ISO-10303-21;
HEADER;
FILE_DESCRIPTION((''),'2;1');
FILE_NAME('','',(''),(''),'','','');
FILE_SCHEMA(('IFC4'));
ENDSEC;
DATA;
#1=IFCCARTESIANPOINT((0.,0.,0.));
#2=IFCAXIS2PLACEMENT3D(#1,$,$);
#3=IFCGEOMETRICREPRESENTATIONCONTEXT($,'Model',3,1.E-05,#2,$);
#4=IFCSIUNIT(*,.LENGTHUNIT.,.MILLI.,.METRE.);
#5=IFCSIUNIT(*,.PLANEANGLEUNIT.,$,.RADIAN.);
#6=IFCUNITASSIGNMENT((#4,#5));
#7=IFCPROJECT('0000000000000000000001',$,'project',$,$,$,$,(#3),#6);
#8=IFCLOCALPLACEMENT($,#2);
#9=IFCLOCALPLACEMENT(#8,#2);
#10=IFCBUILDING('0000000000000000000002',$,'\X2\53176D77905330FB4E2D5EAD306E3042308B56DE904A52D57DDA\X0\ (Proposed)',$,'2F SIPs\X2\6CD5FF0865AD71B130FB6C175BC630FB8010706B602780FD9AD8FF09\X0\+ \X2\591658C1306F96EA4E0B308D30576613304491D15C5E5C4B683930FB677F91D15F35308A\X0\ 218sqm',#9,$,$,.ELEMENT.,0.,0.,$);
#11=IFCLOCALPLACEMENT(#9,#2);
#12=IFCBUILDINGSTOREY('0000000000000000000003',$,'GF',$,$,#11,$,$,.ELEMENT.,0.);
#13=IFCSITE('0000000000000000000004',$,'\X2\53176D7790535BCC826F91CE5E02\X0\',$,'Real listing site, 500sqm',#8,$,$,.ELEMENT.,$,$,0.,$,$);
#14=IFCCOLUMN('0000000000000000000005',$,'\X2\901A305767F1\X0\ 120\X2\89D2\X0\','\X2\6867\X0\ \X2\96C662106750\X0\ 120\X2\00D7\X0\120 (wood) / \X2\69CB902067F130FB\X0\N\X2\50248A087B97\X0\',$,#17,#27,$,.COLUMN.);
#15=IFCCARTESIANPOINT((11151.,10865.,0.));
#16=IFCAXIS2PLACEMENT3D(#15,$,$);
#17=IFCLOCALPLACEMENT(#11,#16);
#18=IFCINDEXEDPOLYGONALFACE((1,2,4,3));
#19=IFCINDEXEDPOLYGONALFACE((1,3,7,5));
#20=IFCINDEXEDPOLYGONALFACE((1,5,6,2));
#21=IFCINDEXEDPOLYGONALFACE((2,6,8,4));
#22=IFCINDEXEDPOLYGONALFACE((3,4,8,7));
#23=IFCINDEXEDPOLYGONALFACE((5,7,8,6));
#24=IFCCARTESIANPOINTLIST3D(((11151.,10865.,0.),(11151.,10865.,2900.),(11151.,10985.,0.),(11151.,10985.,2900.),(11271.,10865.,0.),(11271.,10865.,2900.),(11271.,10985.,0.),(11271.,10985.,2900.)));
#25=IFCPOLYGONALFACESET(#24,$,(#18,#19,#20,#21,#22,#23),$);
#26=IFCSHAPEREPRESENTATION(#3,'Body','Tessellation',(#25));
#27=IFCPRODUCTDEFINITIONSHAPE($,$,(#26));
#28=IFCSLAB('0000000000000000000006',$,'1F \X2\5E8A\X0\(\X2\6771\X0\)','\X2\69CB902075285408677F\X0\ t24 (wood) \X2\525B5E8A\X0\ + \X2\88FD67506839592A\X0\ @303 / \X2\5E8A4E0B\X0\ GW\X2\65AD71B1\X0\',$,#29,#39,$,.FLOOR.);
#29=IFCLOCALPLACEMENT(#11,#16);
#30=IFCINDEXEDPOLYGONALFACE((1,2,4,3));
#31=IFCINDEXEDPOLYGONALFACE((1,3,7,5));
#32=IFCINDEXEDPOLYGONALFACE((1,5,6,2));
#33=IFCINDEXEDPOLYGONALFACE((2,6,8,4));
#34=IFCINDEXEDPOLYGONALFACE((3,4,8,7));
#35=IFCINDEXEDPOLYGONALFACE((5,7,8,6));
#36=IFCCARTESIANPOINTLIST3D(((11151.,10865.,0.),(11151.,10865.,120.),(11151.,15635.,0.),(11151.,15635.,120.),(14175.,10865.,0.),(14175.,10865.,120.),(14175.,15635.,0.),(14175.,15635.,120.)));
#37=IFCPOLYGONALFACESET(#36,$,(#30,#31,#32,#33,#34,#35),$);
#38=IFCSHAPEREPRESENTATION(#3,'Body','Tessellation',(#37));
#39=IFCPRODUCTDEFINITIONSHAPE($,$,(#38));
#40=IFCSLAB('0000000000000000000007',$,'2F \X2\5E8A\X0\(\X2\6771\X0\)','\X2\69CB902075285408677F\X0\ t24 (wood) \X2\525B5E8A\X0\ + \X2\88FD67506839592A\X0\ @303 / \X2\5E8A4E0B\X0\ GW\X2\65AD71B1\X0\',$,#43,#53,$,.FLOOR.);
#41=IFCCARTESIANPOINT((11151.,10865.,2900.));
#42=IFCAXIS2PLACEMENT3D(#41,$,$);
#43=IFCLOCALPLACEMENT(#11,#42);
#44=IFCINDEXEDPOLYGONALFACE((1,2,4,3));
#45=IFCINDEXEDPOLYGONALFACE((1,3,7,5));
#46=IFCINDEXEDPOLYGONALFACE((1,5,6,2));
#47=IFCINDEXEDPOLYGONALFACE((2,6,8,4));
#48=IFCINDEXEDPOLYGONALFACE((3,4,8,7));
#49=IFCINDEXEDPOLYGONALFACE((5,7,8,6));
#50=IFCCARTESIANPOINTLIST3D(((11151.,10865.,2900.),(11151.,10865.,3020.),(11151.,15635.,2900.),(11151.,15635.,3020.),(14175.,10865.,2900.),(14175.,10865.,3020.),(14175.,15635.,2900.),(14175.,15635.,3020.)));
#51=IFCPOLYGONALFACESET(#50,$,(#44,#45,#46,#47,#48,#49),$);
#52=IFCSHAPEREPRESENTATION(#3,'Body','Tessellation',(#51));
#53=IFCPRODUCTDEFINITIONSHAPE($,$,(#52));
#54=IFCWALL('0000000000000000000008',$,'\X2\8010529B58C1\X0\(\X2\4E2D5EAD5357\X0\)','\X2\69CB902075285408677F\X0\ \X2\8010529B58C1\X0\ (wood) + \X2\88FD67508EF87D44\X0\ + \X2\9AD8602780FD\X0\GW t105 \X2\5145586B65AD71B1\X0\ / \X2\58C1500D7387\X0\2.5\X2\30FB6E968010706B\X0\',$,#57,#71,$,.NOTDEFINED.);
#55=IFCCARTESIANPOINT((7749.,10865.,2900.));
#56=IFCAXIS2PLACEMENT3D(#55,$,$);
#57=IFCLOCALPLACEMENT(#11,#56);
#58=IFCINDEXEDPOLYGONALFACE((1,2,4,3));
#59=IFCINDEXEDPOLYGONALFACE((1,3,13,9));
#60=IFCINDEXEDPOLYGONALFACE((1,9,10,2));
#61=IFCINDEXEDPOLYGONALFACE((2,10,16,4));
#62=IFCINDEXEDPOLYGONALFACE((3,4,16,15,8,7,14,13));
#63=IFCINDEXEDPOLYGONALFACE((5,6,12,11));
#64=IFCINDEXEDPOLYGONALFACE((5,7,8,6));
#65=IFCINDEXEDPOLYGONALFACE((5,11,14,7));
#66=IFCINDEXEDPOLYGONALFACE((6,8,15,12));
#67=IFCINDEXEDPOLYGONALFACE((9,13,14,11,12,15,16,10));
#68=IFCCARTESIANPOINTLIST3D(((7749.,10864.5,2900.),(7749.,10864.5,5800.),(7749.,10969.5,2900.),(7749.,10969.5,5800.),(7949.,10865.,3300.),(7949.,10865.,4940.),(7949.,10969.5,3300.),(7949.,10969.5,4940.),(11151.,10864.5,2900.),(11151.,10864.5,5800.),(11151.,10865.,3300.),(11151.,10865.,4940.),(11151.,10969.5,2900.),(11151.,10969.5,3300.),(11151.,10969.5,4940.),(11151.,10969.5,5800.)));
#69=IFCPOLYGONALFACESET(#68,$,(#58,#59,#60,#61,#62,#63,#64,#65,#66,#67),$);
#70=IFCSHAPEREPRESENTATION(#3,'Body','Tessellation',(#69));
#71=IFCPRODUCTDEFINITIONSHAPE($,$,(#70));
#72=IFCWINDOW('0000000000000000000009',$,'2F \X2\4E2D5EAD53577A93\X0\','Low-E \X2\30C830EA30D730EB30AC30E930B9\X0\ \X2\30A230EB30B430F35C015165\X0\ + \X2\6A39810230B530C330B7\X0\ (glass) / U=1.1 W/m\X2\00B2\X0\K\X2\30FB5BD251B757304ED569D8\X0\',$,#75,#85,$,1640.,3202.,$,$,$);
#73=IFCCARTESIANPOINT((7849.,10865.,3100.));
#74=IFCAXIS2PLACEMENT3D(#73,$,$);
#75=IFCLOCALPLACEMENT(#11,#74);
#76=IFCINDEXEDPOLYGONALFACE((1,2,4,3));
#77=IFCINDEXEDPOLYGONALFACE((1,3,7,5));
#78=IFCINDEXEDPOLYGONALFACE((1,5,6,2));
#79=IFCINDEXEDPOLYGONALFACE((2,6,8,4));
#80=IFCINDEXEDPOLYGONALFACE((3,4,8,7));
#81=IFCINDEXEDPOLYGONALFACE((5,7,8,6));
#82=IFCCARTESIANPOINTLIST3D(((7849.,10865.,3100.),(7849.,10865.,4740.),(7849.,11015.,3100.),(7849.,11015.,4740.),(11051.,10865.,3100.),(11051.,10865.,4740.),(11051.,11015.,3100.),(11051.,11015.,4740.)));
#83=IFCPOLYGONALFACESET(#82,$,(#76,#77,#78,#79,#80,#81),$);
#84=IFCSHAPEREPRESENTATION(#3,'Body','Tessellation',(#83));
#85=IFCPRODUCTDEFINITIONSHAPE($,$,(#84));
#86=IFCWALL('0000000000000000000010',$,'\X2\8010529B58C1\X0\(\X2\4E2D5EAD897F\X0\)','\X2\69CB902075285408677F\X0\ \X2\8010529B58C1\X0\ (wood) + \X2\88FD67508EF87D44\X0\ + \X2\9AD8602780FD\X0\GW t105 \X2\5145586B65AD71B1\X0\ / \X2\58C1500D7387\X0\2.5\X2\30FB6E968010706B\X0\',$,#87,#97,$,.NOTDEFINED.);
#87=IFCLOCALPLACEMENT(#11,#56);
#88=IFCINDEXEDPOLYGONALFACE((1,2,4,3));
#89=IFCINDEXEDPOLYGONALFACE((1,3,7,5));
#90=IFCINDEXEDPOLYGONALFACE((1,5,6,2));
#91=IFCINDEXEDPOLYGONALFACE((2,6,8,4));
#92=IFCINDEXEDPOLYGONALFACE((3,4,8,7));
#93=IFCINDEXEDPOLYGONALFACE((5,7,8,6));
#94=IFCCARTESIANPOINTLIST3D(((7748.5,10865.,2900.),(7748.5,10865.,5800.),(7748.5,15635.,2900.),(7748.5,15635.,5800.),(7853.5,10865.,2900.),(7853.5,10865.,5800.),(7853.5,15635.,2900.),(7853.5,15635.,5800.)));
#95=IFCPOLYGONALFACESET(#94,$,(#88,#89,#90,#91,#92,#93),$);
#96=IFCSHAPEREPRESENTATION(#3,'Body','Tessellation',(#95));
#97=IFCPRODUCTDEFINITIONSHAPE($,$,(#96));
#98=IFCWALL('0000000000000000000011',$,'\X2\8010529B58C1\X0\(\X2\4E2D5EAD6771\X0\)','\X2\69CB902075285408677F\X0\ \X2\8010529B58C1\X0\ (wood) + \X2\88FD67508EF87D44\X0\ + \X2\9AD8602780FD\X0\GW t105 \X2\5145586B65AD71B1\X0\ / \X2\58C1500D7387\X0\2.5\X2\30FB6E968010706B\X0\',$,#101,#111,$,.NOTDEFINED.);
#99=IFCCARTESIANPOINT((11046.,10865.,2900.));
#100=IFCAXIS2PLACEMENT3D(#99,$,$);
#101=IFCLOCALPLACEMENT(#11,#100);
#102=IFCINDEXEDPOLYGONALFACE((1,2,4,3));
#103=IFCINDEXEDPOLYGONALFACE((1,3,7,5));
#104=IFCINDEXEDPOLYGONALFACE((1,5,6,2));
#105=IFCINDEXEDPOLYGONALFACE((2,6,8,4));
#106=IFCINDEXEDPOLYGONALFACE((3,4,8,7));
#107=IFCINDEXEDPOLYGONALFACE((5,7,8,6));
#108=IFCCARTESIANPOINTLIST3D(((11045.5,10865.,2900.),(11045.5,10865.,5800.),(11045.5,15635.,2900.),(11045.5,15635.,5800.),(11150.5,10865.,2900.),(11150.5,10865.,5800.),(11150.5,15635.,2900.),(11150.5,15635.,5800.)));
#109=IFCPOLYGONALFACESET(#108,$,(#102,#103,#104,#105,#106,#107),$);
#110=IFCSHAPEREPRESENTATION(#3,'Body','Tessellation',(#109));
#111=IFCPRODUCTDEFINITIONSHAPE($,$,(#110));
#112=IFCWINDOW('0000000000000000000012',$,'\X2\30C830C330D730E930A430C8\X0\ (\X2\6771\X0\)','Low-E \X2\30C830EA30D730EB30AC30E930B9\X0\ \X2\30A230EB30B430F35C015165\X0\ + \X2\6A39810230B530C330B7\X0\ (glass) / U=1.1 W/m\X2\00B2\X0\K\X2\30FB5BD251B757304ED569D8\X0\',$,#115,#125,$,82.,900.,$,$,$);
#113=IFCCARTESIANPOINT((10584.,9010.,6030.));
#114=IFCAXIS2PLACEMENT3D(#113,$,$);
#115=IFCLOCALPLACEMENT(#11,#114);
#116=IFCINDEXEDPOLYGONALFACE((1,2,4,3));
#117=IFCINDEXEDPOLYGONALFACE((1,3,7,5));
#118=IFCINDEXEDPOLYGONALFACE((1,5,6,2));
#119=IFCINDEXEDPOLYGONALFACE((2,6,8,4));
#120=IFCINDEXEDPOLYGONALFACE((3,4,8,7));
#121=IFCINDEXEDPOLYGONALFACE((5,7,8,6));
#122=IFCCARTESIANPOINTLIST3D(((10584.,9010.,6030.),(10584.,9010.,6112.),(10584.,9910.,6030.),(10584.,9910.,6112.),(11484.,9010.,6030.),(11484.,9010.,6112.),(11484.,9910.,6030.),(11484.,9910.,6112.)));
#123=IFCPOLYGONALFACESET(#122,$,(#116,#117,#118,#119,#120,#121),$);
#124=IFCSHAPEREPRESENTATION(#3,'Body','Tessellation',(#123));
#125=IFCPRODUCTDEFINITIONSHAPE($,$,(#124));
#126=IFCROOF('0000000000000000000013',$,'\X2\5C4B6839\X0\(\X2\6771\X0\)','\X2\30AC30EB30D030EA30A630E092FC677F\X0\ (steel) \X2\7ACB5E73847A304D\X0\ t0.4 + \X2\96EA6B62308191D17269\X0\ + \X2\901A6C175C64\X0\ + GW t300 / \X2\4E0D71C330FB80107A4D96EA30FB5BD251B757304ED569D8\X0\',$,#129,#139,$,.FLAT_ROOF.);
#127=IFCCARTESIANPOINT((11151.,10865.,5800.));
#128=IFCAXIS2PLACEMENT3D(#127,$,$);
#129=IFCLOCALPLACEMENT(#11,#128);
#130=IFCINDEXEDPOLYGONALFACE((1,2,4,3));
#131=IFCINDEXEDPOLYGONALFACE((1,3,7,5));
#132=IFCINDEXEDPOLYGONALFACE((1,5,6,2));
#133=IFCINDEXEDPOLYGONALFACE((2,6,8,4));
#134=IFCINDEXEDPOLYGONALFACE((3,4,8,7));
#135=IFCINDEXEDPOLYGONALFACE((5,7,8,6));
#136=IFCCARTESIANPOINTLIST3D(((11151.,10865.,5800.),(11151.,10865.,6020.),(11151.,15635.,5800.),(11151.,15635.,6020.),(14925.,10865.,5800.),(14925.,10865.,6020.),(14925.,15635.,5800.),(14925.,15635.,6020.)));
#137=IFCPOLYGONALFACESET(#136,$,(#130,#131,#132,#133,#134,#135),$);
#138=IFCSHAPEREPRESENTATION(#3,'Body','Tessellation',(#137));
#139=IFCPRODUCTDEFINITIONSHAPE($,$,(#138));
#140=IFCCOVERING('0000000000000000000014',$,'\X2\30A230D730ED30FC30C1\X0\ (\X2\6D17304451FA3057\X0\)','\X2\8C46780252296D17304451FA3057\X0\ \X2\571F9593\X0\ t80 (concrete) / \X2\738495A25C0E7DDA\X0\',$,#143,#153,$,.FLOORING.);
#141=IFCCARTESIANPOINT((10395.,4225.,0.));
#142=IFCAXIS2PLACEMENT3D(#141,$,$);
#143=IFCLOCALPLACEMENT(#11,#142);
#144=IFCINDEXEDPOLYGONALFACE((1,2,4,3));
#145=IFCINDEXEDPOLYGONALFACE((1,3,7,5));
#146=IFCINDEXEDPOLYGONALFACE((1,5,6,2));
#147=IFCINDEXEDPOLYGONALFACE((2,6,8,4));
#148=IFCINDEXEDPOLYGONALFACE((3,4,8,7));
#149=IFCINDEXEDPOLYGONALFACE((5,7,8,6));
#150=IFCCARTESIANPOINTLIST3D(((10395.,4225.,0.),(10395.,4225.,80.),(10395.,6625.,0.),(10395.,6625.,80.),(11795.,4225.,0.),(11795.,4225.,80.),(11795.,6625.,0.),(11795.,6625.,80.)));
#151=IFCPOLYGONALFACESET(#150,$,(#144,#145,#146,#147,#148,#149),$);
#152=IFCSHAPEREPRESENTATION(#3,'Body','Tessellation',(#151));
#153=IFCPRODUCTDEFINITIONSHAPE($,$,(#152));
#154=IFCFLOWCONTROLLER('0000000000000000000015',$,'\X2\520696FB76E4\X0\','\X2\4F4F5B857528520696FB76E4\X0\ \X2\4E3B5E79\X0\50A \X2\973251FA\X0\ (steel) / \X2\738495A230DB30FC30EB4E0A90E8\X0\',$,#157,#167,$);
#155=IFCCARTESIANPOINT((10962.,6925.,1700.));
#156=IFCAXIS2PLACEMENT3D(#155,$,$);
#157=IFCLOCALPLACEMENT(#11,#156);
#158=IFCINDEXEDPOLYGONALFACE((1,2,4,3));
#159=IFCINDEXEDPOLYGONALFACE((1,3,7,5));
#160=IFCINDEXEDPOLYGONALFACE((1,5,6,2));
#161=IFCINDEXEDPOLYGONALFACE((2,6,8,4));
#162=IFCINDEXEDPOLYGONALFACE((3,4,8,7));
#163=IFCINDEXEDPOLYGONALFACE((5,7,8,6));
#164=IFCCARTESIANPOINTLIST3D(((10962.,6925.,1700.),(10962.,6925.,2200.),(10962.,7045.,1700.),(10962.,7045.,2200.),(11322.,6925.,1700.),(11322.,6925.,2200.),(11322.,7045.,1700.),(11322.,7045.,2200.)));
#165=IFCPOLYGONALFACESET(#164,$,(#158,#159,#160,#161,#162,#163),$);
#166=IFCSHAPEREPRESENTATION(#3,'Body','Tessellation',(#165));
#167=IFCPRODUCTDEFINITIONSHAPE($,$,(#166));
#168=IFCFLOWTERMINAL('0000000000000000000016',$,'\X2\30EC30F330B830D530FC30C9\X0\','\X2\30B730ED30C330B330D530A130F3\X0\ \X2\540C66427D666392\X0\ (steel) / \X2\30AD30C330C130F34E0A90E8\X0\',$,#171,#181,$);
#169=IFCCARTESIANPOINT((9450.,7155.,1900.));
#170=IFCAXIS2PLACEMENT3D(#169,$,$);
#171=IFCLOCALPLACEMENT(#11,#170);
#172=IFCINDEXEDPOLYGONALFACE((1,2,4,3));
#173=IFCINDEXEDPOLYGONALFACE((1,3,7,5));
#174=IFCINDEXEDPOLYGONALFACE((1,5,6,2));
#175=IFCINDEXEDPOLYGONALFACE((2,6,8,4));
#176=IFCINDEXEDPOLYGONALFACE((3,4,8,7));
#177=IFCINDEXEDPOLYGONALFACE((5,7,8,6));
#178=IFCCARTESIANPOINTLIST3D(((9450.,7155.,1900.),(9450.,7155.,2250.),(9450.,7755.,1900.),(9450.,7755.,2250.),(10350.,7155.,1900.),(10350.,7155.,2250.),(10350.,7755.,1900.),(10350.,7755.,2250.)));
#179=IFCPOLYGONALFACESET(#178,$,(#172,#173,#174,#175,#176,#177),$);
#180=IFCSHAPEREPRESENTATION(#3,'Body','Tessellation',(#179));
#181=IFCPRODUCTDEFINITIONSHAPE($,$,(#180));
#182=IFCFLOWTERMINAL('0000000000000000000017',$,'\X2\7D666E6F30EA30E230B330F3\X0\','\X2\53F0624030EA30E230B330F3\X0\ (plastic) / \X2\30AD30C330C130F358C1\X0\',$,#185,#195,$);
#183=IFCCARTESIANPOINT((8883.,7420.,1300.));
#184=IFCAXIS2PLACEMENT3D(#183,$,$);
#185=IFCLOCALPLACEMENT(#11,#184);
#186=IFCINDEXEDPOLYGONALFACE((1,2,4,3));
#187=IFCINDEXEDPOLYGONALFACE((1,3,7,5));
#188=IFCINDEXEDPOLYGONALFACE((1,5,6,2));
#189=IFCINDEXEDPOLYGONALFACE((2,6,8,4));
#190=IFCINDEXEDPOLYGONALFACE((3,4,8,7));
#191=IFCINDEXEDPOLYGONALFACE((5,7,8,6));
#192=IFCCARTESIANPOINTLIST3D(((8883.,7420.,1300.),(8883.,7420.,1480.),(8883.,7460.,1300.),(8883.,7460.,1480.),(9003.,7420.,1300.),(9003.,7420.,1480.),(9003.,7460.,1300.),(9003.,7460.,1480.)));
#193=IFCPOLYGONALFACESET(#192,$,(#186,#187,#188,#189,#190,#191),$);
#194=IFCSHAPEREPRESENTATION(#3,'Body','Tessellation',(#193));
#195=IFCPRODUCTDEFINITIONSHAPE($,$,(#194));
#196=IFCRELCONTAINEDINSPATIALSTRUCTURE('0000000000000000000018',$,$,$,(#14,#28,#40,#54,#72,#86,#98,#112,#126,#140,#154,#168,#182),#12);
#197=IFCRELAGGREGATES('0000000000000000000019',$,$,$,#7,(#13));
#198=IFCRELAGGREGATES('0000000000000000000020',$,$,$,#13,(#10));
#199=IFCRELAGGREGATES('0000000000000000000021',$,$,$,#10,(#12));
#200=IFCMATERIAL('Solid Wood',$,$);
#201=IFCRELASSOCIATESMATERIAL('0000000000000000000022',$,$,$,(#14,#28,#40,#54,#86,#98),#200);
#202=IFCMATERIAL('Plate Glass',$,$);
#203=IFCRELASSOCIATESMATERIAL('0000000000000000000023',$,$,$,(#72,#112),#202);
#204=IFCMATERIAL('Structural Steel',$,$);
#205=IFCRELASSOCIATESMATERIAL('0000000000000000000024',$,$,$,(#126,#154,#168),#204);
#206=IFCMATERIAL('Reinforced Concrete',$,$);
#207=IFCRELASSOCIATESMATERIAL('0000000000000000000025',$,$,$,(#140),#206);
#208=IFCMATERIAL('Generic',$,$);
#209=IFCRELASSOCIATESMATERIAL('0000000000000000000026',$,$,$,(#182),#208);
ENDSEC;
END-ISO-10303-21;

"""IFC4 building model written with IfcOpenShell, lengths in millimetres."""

from ifc_helpers import new_model, si_unit, frame, frame_2d, origin, place, context, project, spatial, rectangle, extrude, material, element, fill, save


model = new_model("IFC4")

# Units and contexts
model_context = context("Model", 3, precision=1e-05, world=origin())
ifc_project = project(units=[si_unit("LENGTHUNIT", "METRE", prefix="MILLI"), si_unit("PLANEANGLEUNIT", "RADIAN")], contexts=[model_context])

# Site, building, storey
site_placement = place(None, origin())
site = spatial("IfcSite", under=ifc_project, at=site_placement, Name="北海道富良野市", ObjectType="Real listing site, 500sqm", CompositionType="ELEMENT", RefElevation=0.0)
building_placement = place(site_placement, origin())
building = spatial("IfcBuilding", under=site, at=building_placement, Name="北海道・中庭のある回遊動線 (Proposed)", ObjectType="2F SIPs法（断熱・気密・耐火性能高）+ 外壁は雪下ろし易い金属屋根・板金張り 218sqm", CompositionType="ELEMENT", ElevationOfRefHeight=0.0, ElevationOfTerrain=0.0)
storey_placement = place(building_placement, origin())
storey = spatial("IfcBuildingStorey", under=building, at=storey_placement, Name="GF", CompositionType="ELEMENT", Elevation=0.0)

# Column
ifc_material_1 = material(Name="Solid Wood")
column_1_placement = place(storey_placement, frame((11151.0, 10865.0, 0.0)))
element("IfcColumn", 1, at=column_1_placement, inside=storey, material=ifc_material_1, Name="通し柱 120角", Description="桧 集成材 120×120 (wood) / 構造柱・N値計算", PredefinedType="COLUMN", context=model_context, shape_type="SweptSolid", body=[
    extrude(rectangle(XDim=120.0, YDim=120.0, at=frame_2d((60.0, 60.0))), frame((11151.0, 10865.0, 0.0)), (0.0, 0.0, 1.0), 2900.0),
])

# Slabs
slab_1_placement = place(storey_placement, frame((11151.0, 10865.0, 0.0)))
element("IfcSlab", 2, at=slab_1_placement, inside=storey, material=ifc_material_1, Name="1F 床(東)", Description="構造用合板 t24 (wood) 剛床 + 製材根太 @303 / 床下 GW断熱", PredefinedType="FLOOR", context=model_context, shape_type="SweptSolid", body=[
    extrude(rectangle(XDim=3024.0, YDim=4770.0, at=frame_2d((1512.0, 2385.0))), frame((11151.0, 10865.0, 0.0)), (0.0, 0.0, 1.0), 120.0),
])
slab_2_placement = place(storey_placement, frame((11151.0, 10865.0, 2900.0)))
element("IfcSlab", 3, at=slab_2_placement, inside=storey, material=ifc_material_1, Name="2F 床(東)", Description="構造用合板 t24 (wood) 剛床 + 製材根太 @303 / 床下 GW断熱", PredefinedType="FLOOR", context=model_context, shape_type="SweptSolid", body=[
    extrude(rectangle(XDim=3024.0, YDim=4770.0, at=frame_2d((1512.0, 2385.0))), frame((11151.0, 10865.0, 2900.0)), (0.0, 0.0, 1.0), 120.0),
])

# Wall, opening, window
wall_1_placement = place(storey_placement, frame((7749.0, 10865.0, 2900.0)))
wall_1 = element("IfcWall", 4, at=wall_1_placement, inside=storey, material=ifc_material_1, Name="耐力壁(中庭南)", Description="構造用合板 耐力壁 (wood) + 製材軸組 + 高性能GW t105 充填断熱 / 壁倍率2.5・準耐火", PredefinedType="NOTDEFINED", context=model_context, shape_type="SweptSolid", body=[
    extrude(rectangle(XDim=3402.0, YDim=105.0, at=frame_2d((1701.0, 52.0))), frame((7749.0, 10865.0, 2900.0)), (0.0, 0.0, 1.0), 2900.0),
])
opening_placement = place(storey_placement, frame((7849.0, 10865.0, 3100.0)))
opening = element("IfcOpeningElement", 5, at=opening_placement, cuts=wall_1, PredefinedType="NOTDEFINED", context=model_context, shape_type="SweptSolid", body=[
    extrude(rectangle(XDim=3202.0, YDim=150.0, at=frame_2d((1601.0, 75.0))), frame((7849.0, 10865.0, 3100.0)), (0.0, 0.0, 1.0), 1640.0),
])
ifc_material_2 = material(Name="Plate Glass")
window_1_placement = place(storey_placement, frame((7849.0, 10865.0, 3100.0)))
window_1 = element("IfcWindow", 6, at=window_1_placement, inside=storey, material=ifc_material_2, Name="2F 中庭南窓", Description="Low-E トリプルガラス アルゴン封入 + 樹脂サッシ (glass) / U=1.1 W/m²K・寒冷地仕様", OverallHeight=1640.0, OverallWidth=3202.0, context=model_context, shape_type="SweptSolid", body=[
    extrude(rectangle(XDim=3202.0, YDim=150.0, at=frame_2d((1601.0, 75.0))), frame((7849.0, 10865.0, 3100.0)), (0.0, 0.0, 1.0), 1640.0),
])
fill(opening, window_1)

# Walls
wall_2_placement = place(storey_placement, frame((7749.0, 10865.0, 2900.0)))
element("IfcWall", 7, at=wall_2_placement, inside=storey, material=ifc_material_1, Name="耐力壁(中庭西)", Description="構造用合板 耐力壁 (wood) + 製材軸組 + 高性能GW t105 充填断熱 / 壁倍率2.5・準耐火", PredefinedType="NOTDEFINED", context=model_context, shape_type="SweptSolid", body=[
    extrude(rectangle(XDim=105.0, YDim=4770.0, at=frame_2d((52.0, 2385.0))), frame((7749.0, 10865.0, 2900.0)), (0.0, 0.0, 1.0), 2900.0),
])
wall_3_placement = place(storey_placement, frame((11046.0, 10865.0, 2900.0)))
element("IfcWall", 8, at=wall_3_placement, inside=storey, material=ifc_material_1, Name="耐力壁(中庭東)", Description="構造用合板 耐力壁 (wood) + 製材軸組 + 高性能GW t105 充填断熱 / 壁倍率2.5・準耐火", PredefinedType="NOTDEFINED", context=model_context, shape_type="SweptSolid", body=[
    extrude(rectangle(XDim=105.0, YDim=4770.0, at=frame_2d((52.0, 2385.0))), frame((11046.0, 10865.0, 2900.0)), (0.0, 0.0, 1.0), 2900.0),
])

# Window
window_2_placement = place(storey_placement, frame((10584.0, 9010.0, 6030.0)))
element("IfcWindow", 9, at=window_2_placement, inside=storey, material=ifc_material_2, Name="トップライト (東)", Description="Low-E トリプルガラス アルゴン封入 + 樹脂サッシ (glass) / U=1.1 W/m²K・寒冷地仕様", OverallHeight=82.0, OverallWidth=900.0, context=model_context, shape_type="SweptSolid", body=[
    extrude(rectangle(XDim=900.0, YDim=900.0, at=frame_2d((450.0, 450.0))), frame((10584.0, 9010.0, 6030.0)), (0.0, 0.0, 1.0), 82.0),
])

# Roof
ifc_material_3 = material(Name="Structural Steel")
for number, where, name in (
    (10, (11151.0, 10865.0, 5800.0), "屋根(東)"),
):
    element("IfcRoof", number, at=place(storey_placement, frame(where)), inside=storey, material=ifc_material_3, Name=name, Description="ガルバリウム鋼板 (steel) 立平葺き t0.4 + 雪止め金物 + 通気層 + GW t300 / 不燃・耐積雪・寒冷地仕様", PredefinedType="FLAT_ROOF", context=model_context, shape_type="SweptSolid", body=[
        extrude(rectangle(XDim=3774.0, YDim=4770.0, at=frame_2d((1887.0, 2385.0))), frame((11151.0, 10865.0, 5800.0)), (0.0, 0.0, 1.0), 220.0),
    ])

# Covering
ifc_material_4 = material(Name="Reinforced Concrete")
covering_placement = place(storey_placement, frame((10395.0, 4225.0, 0.0)))
element("IfcCovering", 11, at=covering_placement, inside=storey, material=ifc_material_4, Name="アプローチ (洗い出し)", Description="豆砂利洗い出し 土間 t80 (concrete) / 玄関導線", PredefinedType="FLOORING", context=model_context, shape_type="SweptSolid", body=[
    extrude(rectangle(XDim=1400.0, YDim=2400.0, at=frame_2d((700.0, 1200.0))), frame((10395.0, 4225.0, 0.0)), (0.0, 0.0, 1.0), 80.0),
])

# Flow controller
flow_controller_placement = place(storey_placement, frame((10962.0, 6925.0, 1700.0)))
element("IfcFlowController", 12, at=flow_controller_placement, inside=storey, material=ifc_material_3, Name="分電盤", Description="住宅用分電盤 主幹50A 露出 (steel) / 玄関ホール上部", context=model_context, shape_type="SweptSolid", body=[
    extrude(rectangle(XDim=360.0, YDim=120.0, at=frame_2d((180.0, 60.0))), frame((10962.0, 6925.0, 1700.0)), (0.0, 0.0, 1.0), 500.0),
])

# Flow terminals
flow_terminal_1_placement = place(storey_placement, frame((9450.0, 7155.0, 1900.0)))
element("IfcFlowTerminal", 13, at=flow_terminal_1_placement, inside=storey, material=ifc_material_3, Name="レンジフード", Description="シロッコファン 同時給排 (steel) / キッチン上部", context=model_context, shape_type="SweptSolid", body=[
    extrude(rectangle(XDim=900.0, YDim=600.0, at=frame_2d((450.0, 300.0))), frame((9450.0, 7155.0, 1900.0)), (0.0, 0.0, 1.0), 350.0),
])
ifc_material_5 = material(Name="Generic")
flow_terminal_2_placement = place(storey_placement, frame((8883.0, 7420.0, 1300.0)))
element("IfcFlowTerminal", 14, at=flow_terminal_2_placement, inside=storey, material=ifc_material_5, Name="給湯リモコン", Description="台所リモコン (plastic) / キッチン壁", context=model_context, shape_type="SweptSolid", body=[
    extrude(rectangle(XDim=120.0, YDim=40.0, at=frame_2d((60.0, 20.0))), frame((8883.0, 7420.0, 1300.0)), (0.0, 0.0, 1.0), 180.0),
])

save(model, "model.ifc")
